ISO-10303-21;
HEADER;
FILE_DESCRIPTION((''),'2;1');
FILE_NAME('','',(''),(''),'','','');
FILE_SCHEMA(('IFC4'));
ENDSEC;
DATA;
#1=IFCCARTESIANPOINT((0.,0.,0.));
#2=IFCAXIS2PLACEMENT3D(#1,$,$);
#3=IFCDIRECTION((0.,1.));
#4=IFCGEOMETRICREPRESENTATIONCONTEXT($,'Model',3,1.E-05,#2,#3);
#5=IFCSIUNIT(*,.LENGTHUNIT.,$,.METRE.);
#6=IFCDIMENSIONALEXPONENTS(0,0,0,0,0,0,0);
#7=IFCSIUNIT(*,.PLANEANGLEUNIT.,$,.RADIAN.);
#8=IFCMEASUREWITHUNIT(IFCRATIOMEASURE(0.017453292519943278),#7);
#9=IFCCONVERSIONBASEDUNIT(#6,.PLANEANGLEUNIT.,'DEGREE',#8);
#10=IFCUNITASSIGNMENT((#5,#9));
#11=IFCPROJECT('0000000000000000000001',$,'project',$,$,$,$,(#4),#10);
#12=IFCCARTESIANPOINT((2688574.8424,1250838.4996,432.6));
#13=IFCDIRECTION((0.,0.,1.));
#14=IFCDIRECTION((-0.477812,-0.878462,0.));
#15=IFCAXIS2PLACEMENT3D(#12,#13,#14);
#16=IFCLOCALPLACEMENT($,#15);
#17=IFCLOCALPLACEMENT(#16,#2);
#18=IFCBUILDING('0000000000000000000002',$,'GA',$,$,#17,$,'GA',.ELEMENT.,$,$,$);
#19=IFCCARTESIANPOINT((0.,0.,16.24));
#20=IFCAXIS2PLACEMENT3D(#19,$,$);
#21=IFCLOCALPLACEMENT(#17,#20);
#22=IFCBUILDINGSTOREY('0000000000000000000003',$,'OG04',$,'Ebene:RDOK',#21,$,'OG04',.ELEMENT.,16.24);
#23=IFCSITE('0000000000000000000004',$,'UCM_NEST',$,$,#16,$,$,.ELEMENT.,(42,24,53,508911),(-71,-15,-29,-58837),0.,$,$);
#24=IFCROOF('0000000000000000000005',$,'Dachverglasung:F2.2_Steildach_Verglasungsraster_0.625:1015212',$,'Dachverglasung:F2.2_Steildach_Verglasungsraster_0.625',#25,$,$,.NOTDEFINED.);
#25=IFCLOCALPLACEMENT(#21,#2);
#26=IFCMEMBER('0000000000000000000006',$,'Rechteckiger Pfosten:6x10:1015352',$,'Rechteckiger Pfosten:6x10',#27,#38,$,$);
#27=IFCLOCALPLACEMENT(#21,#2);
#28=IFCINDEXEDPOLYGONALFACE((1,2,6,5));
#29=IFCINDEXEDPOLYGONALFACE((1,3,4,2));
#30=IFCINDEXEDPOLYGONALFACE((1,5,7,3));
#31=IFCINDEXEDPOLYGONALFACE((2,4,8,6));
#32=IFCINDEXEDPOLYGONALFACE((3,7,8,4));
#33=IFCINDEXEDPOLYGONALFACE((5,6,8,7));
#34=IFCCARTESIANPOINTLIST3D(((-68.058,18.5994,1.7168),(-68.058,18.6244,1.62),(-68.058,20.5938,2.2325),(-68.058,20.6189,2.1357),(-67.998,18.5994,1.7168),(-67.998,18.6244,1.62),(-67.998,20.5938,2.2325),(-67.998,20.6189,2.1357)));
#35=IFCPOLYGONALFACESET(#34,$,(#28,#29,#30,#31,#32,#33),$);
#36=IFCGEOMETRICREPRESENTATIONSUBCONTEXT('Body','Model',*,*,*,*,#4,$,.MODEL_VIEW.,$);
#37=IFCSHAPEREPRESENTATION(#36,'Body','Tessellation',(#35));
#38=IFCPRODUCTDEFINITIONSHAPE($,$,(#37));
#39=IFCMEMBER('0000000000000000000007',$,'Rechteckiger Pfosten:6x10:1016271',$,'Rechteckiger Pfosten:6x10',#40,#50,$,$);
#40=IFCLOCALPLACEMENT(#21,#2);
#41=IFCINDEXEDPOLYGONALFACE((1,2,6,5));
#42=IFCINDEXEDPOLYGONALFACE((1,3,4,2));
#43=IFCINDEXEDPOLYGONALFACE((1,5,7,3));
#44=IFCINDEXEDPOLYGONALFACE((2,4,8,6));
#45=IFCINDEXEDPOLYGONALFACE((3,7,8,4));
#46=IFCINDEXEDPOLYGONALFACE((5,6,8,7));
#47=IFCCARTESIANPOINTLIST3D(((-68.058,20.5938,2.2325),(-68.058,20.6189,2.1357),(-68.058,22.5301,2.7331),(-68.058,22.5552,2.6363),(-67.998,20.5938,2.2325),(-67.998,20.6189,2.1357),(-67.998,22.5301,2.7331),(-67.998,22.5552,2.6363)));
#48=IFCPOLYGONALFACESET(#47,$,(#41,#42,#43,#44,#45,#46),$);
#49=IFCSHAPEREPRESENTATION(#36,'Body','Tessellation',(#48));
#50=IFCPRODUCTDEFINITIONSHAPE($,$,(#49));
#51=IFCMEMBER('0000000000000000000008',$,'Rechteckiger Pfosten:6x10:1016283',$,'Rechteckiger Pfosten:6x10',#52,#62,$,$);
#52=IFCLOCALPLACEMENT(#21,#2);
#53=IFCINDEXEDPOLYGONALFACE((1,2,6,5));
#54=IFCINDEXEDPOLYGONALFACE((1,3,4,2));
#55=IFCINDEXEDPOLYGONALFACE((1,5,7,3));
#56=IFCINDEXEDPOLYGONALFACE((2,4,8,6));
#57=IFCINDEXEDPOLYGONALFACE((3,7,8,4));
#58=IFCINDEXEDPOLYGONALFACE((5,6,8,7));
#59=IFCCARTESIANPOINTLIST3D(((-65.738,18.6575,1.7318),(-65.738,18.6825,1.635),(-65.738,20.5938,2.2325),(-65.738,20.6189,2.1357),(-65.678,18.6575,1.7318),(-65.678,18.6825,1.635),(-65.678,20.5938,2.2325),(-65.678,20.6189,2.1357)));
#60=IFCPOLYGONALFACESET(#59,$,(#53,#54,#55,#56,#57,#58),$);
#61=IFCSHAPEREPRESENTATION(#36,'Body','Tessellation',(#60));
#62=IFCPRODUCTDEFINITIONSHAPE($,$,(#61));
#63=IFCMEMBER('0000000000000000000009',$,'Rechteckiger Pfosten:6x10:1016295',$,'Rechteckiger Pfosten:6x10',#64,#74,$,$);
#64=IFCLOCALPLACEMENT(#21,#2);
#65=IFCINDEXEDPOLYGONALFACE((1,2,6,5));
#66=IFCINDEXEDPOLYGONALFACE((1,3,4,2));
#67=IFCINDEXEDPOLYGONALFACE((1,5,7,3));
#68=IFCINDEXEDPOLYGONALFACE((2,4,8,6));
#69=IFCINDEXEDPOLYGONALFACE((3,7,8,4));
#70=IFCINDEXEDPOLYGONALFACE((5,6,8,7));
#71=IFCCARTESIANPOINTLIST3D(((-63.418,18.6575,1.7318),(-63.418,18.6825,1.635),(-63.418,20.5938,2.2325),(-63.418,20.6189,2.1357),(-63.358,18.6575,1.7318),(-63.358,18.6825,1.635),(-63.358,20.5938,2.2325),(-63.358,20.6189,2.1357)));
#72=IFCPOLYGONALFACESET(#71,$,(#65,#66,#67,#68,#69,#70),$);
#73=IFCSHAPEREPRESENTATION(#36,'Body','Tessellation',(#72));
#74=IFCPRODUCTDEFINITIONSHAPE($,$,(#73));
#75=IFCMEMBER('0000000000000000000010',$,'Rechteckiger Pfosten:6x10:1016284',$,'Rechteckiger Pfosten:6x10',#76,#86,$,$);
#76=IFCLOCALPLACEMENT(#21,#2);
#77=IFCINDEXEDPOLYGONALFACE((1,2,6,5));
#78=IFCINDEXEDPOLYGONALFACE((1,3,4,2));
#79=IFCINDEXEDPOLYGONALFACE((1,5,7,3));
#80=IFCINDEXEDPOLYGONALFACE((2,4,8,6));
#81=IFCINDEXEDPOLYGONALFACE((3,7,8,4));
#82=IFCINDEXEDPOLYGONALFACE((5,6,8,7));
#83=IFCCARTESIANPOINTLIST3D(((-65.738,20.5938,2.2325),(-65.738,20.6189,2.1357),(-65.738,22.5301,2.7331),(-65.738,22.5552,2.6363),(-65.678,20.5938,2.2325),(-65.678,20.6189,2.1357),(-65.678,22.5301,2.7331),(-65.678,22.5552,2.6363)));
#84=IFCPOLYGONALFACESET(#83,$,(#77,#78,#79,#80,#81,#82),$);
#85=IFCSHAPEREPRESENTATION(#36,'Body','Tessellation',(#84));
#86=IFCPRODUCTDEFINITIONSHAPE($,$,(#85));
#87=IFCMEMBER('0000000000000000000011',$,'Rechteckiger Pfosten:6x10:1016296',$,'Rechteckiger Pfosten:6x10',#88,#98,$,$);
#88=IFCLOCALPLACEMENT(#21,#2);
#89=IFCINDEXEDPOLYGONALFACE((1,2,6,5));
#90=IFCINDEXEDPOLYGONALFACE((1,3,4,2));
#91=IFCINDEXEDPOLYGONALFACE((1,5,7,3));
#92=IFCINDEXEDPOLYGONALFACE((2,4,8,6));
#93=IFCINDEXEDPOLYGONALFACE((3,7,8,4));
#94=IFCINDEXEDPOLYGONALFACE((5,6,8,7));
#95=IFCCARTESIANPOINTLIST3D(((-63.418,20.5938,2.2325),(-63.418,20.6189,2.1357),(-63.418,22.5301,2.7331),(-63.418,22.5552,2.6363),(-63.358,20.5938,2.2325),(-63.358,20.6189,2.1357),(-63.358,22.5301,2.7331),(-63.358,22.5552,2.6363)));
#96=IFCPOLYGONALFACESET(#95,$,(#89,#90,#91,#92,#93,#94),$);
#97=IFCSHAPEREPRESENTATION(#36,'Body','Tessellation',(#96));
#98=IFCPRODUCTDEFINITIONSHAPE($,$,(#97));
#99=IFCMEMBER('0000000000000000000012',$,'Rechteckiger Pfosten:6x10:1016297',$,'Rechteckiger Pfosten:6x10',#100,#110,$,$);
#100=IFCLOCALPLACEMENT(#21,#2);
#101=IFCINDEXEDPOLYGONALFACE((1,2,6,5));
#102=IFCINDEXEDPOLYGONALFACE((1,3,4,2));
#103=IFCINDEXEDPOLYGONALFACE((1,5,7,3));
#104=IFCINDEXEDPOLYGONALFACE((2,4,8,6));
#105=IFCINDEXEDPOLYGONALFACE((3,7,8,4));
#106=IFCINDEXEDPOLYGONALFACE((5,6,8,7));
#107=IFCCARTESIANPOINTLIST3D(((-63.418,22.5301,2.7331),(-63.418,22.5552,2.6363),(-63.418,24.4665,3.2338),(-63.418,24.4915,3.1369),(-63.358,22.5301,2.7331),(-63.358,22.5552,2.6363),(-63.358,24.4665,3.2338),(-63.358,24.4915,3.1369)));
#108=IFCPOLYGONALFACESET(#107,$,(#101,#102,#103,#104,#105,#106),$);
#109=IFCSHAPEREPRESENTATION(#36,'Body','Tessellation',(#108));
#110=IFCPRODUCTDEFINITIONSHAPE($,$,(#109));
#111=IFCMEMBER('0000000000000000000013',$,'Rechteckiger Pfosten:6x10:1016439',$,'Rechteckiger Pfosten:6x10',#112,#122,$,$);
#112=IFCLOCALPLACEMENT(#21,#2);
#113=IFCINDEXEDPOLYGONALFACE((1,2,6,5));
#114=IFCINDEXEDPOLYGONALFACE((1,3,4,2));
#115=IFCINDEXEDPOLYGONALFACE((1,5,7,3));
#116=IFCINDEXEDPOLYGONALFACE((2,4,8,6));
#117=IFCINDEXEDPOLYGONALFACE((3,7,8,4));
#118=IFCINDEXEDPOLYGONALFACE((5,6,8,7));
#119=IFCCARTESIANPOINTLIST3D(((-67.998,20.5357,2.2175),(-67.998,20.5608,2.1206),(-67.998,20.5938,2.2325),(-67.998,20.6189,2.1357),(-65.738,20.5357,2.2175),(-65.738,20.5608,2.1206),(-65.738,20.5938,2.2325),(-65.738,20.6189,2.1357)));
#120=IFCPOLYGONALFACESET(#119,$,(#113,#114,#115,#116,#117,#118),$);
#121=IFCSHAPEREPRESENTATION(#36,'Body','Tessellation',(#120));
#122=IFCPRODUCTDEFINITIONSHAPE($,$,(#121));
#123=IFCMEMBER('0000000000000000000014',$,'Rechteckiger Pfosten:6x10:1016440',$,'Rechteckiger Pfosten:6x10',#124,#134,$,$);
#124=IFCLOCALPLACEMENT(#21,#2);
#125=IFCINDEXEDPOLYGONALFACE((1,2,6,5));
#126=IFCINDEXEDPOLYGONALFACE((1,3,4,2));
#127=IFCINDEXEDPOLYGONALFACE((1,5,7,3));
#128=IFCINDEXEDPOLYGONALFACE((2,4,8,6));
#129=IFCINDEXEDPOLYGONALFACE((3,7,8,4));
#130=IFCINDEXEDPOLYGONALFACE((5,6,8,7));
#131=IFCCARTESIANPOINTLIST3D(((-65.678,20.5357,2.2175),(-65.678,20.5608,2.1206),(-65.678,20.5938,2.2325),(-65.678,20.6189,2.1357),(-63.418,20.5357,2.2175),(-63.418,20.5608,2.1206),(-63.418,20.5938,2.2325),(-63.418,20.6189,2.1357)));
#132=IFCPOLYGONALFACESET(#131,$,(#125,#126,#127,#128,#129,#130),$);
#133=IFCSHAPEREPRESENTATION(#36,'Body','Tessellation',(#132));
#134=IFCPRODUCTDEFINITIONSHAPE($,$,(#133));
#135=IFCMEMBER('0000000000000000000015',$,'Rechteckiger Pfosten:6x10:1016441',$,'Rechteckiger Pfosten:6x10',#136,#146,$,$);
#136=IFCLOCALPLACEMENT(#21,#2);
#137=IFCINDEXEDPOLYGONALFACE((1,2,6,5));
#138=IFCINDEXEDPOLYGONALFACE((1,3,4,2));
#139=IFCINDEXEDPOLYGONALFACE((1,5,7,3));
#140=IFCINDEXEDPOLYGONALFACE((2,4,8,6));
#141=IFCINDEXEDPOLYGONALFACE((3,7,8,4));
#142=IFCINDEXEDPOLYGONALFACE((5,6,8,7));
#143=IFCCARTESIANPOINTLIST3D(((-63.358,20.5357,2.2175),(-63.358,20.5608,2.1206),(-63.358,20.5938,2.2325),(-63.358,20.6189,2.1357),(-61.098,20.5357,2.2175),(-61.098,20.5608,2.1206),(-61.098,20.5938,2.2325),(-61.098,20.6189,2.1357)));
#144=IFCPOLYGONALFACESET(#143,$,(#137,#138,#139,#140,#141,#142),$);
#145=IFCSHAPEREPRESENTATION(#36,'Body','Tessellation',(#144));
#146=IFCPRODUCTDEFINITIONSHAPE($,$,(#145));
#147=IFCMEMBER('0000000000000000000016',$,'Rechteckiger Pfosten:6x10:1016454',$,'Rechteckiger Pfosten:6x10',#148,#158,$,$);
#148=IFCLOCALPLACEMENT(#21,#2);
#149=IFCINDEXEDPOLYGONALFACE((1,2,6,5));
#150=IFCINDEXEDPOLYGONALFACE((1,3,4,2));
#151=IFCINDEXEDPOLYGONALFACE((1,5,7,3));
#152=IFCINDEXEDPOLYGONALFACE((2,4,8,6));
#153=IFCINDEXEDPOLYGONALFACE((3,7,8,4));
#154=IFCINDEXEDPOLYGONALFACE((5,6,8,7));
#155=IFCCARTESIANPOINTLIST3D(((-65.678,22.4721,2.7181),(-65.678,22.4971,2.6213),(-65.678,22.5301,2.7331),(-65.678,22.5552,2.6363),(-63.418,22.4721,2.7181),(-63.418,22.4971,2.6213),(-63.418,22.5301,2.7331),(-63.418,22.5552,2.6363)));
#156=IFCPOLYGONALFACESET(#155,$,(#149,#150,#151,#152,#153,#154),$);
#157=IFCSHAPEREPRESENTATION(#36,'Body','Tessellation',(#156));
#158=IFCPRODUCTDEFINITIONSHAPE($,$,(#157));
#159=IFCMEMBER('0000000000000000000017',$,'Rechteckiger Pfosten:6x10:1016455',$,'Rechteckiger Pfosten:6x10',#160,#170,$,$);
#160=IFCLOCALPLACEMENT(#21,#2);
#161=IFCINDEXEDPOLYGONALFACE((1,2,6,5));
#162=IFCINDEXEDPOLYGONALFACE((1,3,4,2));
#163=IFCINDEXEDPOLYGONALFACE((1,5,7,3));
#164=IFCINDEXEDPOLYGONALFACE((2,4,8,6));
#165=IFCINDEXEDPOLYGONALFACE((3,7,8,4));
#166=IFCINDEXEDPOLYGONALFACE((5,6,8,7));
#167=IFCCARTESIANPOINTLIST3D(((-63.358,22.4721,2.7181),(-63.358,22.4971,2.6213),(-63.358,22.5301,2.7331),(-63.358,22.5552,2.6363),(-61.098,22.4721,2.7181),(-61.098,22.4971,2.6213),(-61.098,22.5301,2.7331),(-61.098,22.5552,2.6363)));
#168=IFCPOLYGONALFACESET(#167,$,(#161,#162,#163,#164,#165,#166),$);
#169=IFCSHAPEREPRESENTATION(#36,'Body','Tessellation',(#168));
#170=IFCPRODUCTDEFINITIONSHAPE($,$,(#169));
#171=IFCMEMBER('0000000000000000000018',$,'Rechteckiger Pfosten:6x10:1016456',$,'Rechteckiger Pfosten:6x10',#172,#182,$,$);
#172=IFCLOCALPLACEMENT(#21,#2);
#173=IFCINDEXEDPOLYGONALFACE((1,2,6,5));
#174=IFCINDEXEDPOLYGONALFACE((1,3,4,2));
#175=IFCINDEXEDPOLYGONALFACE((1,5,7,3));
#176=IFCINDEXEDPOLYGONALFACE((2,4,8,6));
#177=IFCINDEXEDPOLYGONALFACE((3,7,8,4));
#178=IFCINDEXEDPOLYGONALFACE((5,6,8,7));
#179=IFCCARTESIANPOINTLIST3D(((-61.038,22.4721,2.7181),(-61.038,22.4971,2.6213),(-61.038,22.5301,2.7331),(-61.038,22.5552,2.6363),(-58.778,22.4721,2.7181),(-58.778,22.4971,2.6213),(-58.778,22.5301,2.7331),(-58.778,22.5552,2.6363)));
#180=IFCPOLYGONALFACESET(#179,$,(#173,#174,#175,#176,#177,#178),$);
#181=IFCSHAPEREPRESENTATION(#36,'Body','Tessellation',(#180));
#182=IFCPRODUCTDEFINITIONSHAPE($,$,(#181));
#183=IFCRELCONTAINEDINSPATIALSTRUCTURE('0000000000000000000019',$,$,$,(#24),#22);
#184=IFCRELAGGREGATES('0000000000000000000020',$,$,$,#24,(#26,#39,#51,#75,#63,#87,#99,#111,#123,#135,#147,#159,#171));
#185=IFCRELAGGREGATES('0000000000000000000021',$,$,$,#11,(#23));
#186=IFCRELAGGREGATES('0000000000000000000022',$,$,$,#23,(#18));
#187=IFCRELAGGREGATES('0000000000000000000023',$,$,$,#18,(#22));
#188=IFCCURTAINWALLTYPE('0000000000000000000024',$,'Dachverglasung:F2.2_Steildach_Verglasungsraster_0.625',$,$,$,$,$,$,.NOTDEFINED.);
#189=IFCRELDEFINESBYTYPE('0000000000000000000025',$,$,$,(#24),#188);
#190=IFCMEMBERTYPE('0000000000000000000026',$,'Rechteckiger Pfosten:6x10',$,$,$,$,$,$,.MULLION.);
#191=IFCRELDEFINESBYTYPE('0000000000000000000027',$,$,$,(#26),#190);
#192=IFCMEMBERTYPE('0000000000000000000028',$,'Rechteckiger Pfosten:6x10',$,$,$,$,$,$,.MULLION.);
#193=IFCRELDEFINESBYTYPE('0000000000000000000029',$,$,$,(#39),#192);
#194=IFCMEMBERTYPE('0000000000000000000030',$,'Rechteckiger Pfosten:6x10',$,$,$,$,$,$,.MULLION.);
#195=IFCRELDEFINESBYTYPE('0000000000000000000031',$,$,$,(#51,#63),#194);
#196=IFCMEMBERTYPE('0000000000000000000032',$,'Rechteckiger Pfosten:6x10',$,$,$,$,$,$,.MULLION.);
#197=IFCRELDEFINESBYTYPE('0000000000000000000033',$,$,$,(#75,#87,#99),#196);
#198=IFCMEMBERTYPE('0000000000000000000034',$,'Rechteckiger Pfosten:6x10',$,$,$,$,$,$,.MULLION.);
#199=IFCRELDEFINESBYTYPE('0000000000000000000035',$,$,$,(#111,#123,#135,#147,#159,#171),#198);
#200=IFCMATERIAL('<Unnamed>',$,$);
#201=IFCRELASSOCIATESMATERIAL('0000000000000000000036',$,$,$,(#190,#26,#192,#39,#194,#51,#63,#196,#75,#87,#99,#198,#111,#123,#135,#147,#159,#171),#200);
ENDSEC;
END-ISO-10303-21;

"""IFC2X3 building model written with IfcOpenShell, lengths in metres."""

from ifc_helpers import new_model, entity, si_unit, converted_unit, direction, frame, origin, origin_2d_with_axis, place, context, subcontext, project, spatial, rectangle, extrude, source, transform, mapped, material, type_object, type_shapes, element, aggregate, save


model = new_model("IFC2X3")

# Units and contexts
model_context = context("Model", 3, precision=1e-05, world=origin(), true_north=direction((0.0, 1.0)))
body_context = subcontext(model_context, "Body", "Model", "MODEL_VIEW")
ifc_project = project(units=[si_unit("LENGTHUNIT", "METRE"), converted_unit("PLANEANGLEUNIT", "DEGREE", entity("IfcRatioMeasure", 0.017453292519943278), si_unit("PLANEANGLEUNIT", "RADIAN"), dimensions=[0, 0, 0, 0, 0, 0, 0])], contexts=[model_context])

# Site, building, storey
site_placement = place(None, frame((2688574.8424, 1250838.4996, 432.6), z_axis=(0.0, 0.0, 1.0), x_axis=(-0.477812, -0.878462, 0.0)))
site = spatial("IfcSite", under=ifc_project, at=site_placement, Name="UCM_NEST", CompositionType="ELEMENT", RefLatitude=(42, 24, 53, 508911), RefLongitude=(-71, -15, -29, -58837), RefElevation=0.0)
building_placement = place(site_placement, origin())
building = spatial("IfcBuilding", under=site, at=building_placement, Name="GA", LongName="GA", CompositionType="ELEMENT")
storey_placement = place(building_placement, frame((0.0, 0.0, 16.24)))
storey = spatial("IfcBuildingStorey", under=building, at=storey_placement, Name="OG04", ObjectType="Ebene:RDOK", LongName="OG04", CompositionType="ELEMENT", Elevation=16.24)

# Roof, members
curtain_wall_type = type_object("IfcCurtainWallType", Name="Dachverglasung:F2.2_Steildach_Verglasungsraster_0.625", PredefinedType="NOTDEFINED")
roof_placement = place(storey_placement, frame((0.0, 0.0, -16.24)))
roof = element("IfcRoof", 1, at=roof_placement, inside=storey, type_object=curtain_wall_type, Name="Dachverglasung:F2.2_Steildach_Verglasungsraster_0.625:1015212", ObjectType="Dachverglasung:F2.2_Steildach_Verglasungsraster_0.625", ShapeType="NOTDEFINED")
ifc_material_1 = material(Name="<Unnamed>")
member_type_1 = type_object("IfcMemberType", Name="Rechteckiger Pfosten:6x10", PredefinedType="MULLION", material=ifc_material_1)
shared_shape_1 = source(origin(), body_context, "Body", "SweptSolid", [
    extrude(rectangle(XDim=0.1, YDim=0.06, at=origin_2d_with_axis()), frame((-0.03, -0.05, -2.06), z_axis=(0.0, 0.0, 1.0), x_axis=(0.0, -1.0, 0.0)), (0.0, 0.0, 1.0), 2.06),
])
type_shapes(member_type_1, [shared_shape_1])
member_1_placement = place(roof_placement, frame((-68.058, 18.6244, 17.86), z_axis=(0.0, -0.968163, -0.250322), x_axis=(-1.0, 0.0, 0.0)))
member_1 = element("IfcMember", 2, at=member_1_placement, type_object=member_type_1, material=ifc_material_1, Name="Rechteckiger Pfosten:6x10:1015352", ObjectType="Rechteckiger Pfosten:6x10", context=body_context, shape_type="MappedRepresentation", body=[
    mapped(shared_shape_1, transform((0.0, 0.0, 0.0), scale=1.0)),
])
member_type_2 = type_object("IfcMemberType", Name="Rechteckiger Pfosten:6x10", PredefinedType="MULLION", material=ifc_material_1)
shared_shape_2 = source(origin(), body_context, "Body", "SweptSolid", [
    extrude(rectangle(XDim=0.1, YDim=0.06, at=origin_2d_with_axis()), frame((-0.03, -0.05, -2.0), z_axis=(0.0, 0.0, 1.0), x_axis=(0.0, -1.0, 0.0)), (0.0, 0.0, 1.0), 2.0),
])
type_shapes(member_type_2, [shared_shape_2])
member_2_placement = place(roof_placement, frame((-68.058, 20.6189, 18.3757), z_axis=(0.0, -0.968163, -0.250322), x_axis=(-1.0, 0.0, 0.0)))
member_2 = element("IfcMember", 3, at=member_2_placement, type_object=member_type_2, material=ifc_material_1, Name="Rechteckiger Pfosten:6x10:1016271", ObjectType="Rechteckiger Pfosten:6x10", context=body_context, shape_type="MappedRepresentation", body=[
    mapped(shared_shape_2, transform((0.0, 0.0, 0.0), scale=1.0)),
])
member_type_3 = type_object("IfcMemberType", Name="Rechteckiger Pfosten:6x10", PredefinedType="MULLION", material=ifc_material_1)
shared_shape_3 = source(origin(), body_context, "Body", "SweptSolid", [
    extrude(rectangle(XDim=0.1, YDim=0.06, at=origin_2d_with_axis()), frame((-0.03, -0.05, -2.0), z_axis=(0.0, 0.0, 1.0), x_axis=(0.0, -1.0, 0.0)), (0.0, 0.0, 1.0), 2.0),
])
type_shapes(member_type_3, [shared_shape_3])
member_3_placement = place(roof_placement, frame((-65.678, 20.6189, 18.3757), z_axis=(0.0, 0.968163, 0.250322), x_axis=(1.0, 0.0, 0.0)))
member_3 = element("IfcMember", 4, at=member_3_placement, type_object=member_type_3, material=ifc_material_1, Name="Rechteckiger Pfosten:6x10:1016283", ObjectType="Rechteckiger Pfosten:6x10", context=body_context, shape_type="MappedRepresentation", body=[
    mapped(shared_shape_3, transform((0.0, 0.0, 0.0), scale=1.0)),
])
member_4_placement = place(roof_placement, frame((-63.358, 20.6189, 18.3757), z_axis=(0.0, 0.968163, 0.250322), x_axis=(1.0, 0.0, 0.0)))
member_4 = element("IfcMember", 5, at=member_4_placement, type_object=member_type_3, material=ifc_material_1, Name="Rechteckiger Pfosten:6x10:1016295", ObjectType="Rechteckiger Pfosten:6x10", context=body_context, shape_type="MappedRepresentation", body=[
    mapped(shared_shape_3, transform((0.0, 0.0, 0.0), scale=1.0)),
])
member_type_4 = type_object("IfcMemberType", Name="Rechteckiger Pfosten:6x10", PredefinedType="MULLION", material=ifc_material_1)
shared_shape_4 = source(origin(), body_context, "Body", "SweptSolid", [
    extrude(rectangle(XDim=0.1, YDim=0.06, at=origin_2d_with_axis()), frame((-0.03, -0.05, -2.0), z_axis=(0.0, 0.0, 1.0), x_axis=(0.0, -1.0, 0.0)), (0.0, 0.0, 1.0), 2.0),
])
type_shapes(member_type_4, [shared_shape_4])
member_5_placement = place(roof_placement, frame((-65.678, 22.5552, 18.8763), z_axis=(0.0, 0.968163, 0.250322), x_axis=(1.0, 0.0, 0.0)))
member_5 = element("IfcMember", 6, at=member_5_placement, type_object=member_type_4, material=ifc_material_1, Name="Rechteckiger Pfosten:6x10:1016284", ObjectType="Rechteckiger Pfosten:6x10", context=body_context, shape_type="MappedRepresentation", body=[
    mapped(shared_shape_4, transform((0.0, 0.0, 0.0), scale=1.0)),
])
member_6_placement = place(roof_placement, frame((-63.358, 22.5552, 18.8763), z_axis=(0.0, 0.968163, 0.250322), x_axis=(1.0, 0.0, 0.0)))
member_6 = element("IfcMember", 7, at=member_6_placement, type_object=member_type_4, material=ifc_material_1, Name="Rechteckiger Pfosten:6x10:1016296", ObjectType="Rechteckiger Pfosten:6x10", context=body_context, shape_type="MappedRepresentation", body=[
    mapped(shared_shape_4, transform((0.0, 0.0, 0.0), scale=1.0)),
])
member_7_placement = place(roof_placement, frame((-63.358, 24.4915, 19.3769), z_axis=(0.0, 0.968163, 0.250322), x_axis=(1.0, 0.0, 0.0)))
member_7 = element("IfcMember", 8, at=member_7_placement, type_object=member_type_4, material=ifc_material_1, Name="Rechteckiger Pfosten:6x10:1016297", ObjectType="Rechteckiger Pfosten:6x10", context=body_context, shape_type="MappedRepresentation", body=[
    mapped(shared_shape_4, transform((0.0, 0.0, 0.0), scale=1.0)),
])
member_type_5 = type_object("IfcMemberType", Name="Rechteckiger Pfosten:6x10", PredefinedType="MULLION", material=ifc_material_1)
shared_shape_5 = source(origin(), body_context, "Body", "SweptSolid", [
    extrude(rectangle(XDim=0.1, YDim=0.06, at=origin_2d_with_axis()), frame((-0.03, -0.05, -2.26), z_axis=(0.0, 0.0, 1.0), x_axis=(0.0, -1.0, 0.0)), (0.0, 0.0, 1.0), 2.26),
])
type_shapes(member_type_5, [shared_shape_5])
member_8_placement = place(roof_placement, frame((-67.998, 20.6189, 18.3757), z_axis=(-1.0, 0.0, 0.0), x_axis=(0.0, 0.968163, 0.250322)))
member_8 = element("IfcMember", 9, at=member_8_placement, type_object=member_type_5, material=ifc_material_1, Name="Rechteckiger Pfosten:6x10:1016439", ObjectType="Rechteckiger Pfosten:6x10", context=body_context, shape_type="MappedRepresentation", body=[
    mapped(shared_shape_5, transform((0.0, 0.0, 0.0), scale=1.0)),
])
member_9_placement = place(roof_placement, frame((-65.678, 20.6189, 18.3757), z_axis=(-1.0, 0.0, 0.0), x_axis=(0.0, 0.968163, 0.250322)))
member_9 = element("IfcMember", 10, at=member_9_placement, type_object=member_type_5, material=ifc_material_1, Name="Rechteckiger Pfosten:6x10:1016440", ObjectType="Rechteckiger Pfosten:6x10", context=body_context, shape_type="MappedRepresentation", body=[
    mapped(shared_shape_5, transform((0.0, 0.0, 0.0), scale=1.0)),
])
member_10_placement = place(roof_placement, frame((-63.358, 20.6189, 18.3757), z_axis=(-1.0, 0.0, 0.0), x_axis=(0.0, 0.968163, 0.250322)))
member_10 = element("IfcMember", 11, at=member_10_placement, type_object=member_type_5, material=ifc_material_1, Name="Rechteckiger Pfosten:6x10:1016441", ObjectType="Rechteckiger Pfosten:6x10", context=body_context, shape_type="MappedRepresentation", body=[
    mapped(shared_shape_5, transform((0.0, 0.0, 0.0), scale=1.0)),
])
member_11_placement = place(roof_placement, frame((-65.678, 22.5552, 18.8763), z_axis=(-1.0, 0.0, 0.0), x_axis=(0.0, 0.968163, 0.250322)))
member_11 = element("IfcMember", 12, at=member_11_placement, type_object=member_type_5, material=ifc_material_1, Name="Rechteckiger Pfosten:6x10:1016454", ObjectType="Rechteckiger Pfosten:6x10", context=body_context, shape_type="MappedRepresentation", body=[
    mapped(shared_shape_5, transform((0.0, 0.0, 0.0), scale=1.0)),
])
member_12_placement = place(roof_placement, frame((-63.358, 22.5552, 18.8763), z_axis=(-1.0, 0.0, 0.0), x_axis=(0.0, 0.968163, 0.250322)))
member_12 = element("IfcMember", 13, at=member_12_placement, type_object=member_type_5, material=ifc_material_1, Name="Rechteckiger Pfosten:6x10:1016455", ObjectType="Rechteckiger Pfosten:6x10", context=body_context, shape_type="MappedRepresentation", body=[
    mapped(shared_shape_5, transform((0.0, 0.0, 0.0), scale=1.0)),
])
member_13_placement = place(roof_placement, frame((-61.038, 22.5552, 18.8763), z_axis=(-1.0, 0.0, 0.0), x_axis=(0.0, 0.968163, 0.250322)))
member_13 = element("IfcMember", 14, at=member_13_placement, type_object=member_type_5, material=ifc_material_1, Name="Rechteckiger Pfosten:6x10:1016456", ObjectType="Rechteckiger Pfosten:6x10", context=body_context, shape_type="MappedRepresentation", body=[
    mapped(shared_shape_5, transform((0.0, 0.0, 0.0), scale=1.0)),
])
aggregate(roof, [member_1, member_2, member_3, member_5, member_4, member_6, member_7, member_8, member_9, member_10, member_11, member_12, member_13])

save(model, "model.ifc")
